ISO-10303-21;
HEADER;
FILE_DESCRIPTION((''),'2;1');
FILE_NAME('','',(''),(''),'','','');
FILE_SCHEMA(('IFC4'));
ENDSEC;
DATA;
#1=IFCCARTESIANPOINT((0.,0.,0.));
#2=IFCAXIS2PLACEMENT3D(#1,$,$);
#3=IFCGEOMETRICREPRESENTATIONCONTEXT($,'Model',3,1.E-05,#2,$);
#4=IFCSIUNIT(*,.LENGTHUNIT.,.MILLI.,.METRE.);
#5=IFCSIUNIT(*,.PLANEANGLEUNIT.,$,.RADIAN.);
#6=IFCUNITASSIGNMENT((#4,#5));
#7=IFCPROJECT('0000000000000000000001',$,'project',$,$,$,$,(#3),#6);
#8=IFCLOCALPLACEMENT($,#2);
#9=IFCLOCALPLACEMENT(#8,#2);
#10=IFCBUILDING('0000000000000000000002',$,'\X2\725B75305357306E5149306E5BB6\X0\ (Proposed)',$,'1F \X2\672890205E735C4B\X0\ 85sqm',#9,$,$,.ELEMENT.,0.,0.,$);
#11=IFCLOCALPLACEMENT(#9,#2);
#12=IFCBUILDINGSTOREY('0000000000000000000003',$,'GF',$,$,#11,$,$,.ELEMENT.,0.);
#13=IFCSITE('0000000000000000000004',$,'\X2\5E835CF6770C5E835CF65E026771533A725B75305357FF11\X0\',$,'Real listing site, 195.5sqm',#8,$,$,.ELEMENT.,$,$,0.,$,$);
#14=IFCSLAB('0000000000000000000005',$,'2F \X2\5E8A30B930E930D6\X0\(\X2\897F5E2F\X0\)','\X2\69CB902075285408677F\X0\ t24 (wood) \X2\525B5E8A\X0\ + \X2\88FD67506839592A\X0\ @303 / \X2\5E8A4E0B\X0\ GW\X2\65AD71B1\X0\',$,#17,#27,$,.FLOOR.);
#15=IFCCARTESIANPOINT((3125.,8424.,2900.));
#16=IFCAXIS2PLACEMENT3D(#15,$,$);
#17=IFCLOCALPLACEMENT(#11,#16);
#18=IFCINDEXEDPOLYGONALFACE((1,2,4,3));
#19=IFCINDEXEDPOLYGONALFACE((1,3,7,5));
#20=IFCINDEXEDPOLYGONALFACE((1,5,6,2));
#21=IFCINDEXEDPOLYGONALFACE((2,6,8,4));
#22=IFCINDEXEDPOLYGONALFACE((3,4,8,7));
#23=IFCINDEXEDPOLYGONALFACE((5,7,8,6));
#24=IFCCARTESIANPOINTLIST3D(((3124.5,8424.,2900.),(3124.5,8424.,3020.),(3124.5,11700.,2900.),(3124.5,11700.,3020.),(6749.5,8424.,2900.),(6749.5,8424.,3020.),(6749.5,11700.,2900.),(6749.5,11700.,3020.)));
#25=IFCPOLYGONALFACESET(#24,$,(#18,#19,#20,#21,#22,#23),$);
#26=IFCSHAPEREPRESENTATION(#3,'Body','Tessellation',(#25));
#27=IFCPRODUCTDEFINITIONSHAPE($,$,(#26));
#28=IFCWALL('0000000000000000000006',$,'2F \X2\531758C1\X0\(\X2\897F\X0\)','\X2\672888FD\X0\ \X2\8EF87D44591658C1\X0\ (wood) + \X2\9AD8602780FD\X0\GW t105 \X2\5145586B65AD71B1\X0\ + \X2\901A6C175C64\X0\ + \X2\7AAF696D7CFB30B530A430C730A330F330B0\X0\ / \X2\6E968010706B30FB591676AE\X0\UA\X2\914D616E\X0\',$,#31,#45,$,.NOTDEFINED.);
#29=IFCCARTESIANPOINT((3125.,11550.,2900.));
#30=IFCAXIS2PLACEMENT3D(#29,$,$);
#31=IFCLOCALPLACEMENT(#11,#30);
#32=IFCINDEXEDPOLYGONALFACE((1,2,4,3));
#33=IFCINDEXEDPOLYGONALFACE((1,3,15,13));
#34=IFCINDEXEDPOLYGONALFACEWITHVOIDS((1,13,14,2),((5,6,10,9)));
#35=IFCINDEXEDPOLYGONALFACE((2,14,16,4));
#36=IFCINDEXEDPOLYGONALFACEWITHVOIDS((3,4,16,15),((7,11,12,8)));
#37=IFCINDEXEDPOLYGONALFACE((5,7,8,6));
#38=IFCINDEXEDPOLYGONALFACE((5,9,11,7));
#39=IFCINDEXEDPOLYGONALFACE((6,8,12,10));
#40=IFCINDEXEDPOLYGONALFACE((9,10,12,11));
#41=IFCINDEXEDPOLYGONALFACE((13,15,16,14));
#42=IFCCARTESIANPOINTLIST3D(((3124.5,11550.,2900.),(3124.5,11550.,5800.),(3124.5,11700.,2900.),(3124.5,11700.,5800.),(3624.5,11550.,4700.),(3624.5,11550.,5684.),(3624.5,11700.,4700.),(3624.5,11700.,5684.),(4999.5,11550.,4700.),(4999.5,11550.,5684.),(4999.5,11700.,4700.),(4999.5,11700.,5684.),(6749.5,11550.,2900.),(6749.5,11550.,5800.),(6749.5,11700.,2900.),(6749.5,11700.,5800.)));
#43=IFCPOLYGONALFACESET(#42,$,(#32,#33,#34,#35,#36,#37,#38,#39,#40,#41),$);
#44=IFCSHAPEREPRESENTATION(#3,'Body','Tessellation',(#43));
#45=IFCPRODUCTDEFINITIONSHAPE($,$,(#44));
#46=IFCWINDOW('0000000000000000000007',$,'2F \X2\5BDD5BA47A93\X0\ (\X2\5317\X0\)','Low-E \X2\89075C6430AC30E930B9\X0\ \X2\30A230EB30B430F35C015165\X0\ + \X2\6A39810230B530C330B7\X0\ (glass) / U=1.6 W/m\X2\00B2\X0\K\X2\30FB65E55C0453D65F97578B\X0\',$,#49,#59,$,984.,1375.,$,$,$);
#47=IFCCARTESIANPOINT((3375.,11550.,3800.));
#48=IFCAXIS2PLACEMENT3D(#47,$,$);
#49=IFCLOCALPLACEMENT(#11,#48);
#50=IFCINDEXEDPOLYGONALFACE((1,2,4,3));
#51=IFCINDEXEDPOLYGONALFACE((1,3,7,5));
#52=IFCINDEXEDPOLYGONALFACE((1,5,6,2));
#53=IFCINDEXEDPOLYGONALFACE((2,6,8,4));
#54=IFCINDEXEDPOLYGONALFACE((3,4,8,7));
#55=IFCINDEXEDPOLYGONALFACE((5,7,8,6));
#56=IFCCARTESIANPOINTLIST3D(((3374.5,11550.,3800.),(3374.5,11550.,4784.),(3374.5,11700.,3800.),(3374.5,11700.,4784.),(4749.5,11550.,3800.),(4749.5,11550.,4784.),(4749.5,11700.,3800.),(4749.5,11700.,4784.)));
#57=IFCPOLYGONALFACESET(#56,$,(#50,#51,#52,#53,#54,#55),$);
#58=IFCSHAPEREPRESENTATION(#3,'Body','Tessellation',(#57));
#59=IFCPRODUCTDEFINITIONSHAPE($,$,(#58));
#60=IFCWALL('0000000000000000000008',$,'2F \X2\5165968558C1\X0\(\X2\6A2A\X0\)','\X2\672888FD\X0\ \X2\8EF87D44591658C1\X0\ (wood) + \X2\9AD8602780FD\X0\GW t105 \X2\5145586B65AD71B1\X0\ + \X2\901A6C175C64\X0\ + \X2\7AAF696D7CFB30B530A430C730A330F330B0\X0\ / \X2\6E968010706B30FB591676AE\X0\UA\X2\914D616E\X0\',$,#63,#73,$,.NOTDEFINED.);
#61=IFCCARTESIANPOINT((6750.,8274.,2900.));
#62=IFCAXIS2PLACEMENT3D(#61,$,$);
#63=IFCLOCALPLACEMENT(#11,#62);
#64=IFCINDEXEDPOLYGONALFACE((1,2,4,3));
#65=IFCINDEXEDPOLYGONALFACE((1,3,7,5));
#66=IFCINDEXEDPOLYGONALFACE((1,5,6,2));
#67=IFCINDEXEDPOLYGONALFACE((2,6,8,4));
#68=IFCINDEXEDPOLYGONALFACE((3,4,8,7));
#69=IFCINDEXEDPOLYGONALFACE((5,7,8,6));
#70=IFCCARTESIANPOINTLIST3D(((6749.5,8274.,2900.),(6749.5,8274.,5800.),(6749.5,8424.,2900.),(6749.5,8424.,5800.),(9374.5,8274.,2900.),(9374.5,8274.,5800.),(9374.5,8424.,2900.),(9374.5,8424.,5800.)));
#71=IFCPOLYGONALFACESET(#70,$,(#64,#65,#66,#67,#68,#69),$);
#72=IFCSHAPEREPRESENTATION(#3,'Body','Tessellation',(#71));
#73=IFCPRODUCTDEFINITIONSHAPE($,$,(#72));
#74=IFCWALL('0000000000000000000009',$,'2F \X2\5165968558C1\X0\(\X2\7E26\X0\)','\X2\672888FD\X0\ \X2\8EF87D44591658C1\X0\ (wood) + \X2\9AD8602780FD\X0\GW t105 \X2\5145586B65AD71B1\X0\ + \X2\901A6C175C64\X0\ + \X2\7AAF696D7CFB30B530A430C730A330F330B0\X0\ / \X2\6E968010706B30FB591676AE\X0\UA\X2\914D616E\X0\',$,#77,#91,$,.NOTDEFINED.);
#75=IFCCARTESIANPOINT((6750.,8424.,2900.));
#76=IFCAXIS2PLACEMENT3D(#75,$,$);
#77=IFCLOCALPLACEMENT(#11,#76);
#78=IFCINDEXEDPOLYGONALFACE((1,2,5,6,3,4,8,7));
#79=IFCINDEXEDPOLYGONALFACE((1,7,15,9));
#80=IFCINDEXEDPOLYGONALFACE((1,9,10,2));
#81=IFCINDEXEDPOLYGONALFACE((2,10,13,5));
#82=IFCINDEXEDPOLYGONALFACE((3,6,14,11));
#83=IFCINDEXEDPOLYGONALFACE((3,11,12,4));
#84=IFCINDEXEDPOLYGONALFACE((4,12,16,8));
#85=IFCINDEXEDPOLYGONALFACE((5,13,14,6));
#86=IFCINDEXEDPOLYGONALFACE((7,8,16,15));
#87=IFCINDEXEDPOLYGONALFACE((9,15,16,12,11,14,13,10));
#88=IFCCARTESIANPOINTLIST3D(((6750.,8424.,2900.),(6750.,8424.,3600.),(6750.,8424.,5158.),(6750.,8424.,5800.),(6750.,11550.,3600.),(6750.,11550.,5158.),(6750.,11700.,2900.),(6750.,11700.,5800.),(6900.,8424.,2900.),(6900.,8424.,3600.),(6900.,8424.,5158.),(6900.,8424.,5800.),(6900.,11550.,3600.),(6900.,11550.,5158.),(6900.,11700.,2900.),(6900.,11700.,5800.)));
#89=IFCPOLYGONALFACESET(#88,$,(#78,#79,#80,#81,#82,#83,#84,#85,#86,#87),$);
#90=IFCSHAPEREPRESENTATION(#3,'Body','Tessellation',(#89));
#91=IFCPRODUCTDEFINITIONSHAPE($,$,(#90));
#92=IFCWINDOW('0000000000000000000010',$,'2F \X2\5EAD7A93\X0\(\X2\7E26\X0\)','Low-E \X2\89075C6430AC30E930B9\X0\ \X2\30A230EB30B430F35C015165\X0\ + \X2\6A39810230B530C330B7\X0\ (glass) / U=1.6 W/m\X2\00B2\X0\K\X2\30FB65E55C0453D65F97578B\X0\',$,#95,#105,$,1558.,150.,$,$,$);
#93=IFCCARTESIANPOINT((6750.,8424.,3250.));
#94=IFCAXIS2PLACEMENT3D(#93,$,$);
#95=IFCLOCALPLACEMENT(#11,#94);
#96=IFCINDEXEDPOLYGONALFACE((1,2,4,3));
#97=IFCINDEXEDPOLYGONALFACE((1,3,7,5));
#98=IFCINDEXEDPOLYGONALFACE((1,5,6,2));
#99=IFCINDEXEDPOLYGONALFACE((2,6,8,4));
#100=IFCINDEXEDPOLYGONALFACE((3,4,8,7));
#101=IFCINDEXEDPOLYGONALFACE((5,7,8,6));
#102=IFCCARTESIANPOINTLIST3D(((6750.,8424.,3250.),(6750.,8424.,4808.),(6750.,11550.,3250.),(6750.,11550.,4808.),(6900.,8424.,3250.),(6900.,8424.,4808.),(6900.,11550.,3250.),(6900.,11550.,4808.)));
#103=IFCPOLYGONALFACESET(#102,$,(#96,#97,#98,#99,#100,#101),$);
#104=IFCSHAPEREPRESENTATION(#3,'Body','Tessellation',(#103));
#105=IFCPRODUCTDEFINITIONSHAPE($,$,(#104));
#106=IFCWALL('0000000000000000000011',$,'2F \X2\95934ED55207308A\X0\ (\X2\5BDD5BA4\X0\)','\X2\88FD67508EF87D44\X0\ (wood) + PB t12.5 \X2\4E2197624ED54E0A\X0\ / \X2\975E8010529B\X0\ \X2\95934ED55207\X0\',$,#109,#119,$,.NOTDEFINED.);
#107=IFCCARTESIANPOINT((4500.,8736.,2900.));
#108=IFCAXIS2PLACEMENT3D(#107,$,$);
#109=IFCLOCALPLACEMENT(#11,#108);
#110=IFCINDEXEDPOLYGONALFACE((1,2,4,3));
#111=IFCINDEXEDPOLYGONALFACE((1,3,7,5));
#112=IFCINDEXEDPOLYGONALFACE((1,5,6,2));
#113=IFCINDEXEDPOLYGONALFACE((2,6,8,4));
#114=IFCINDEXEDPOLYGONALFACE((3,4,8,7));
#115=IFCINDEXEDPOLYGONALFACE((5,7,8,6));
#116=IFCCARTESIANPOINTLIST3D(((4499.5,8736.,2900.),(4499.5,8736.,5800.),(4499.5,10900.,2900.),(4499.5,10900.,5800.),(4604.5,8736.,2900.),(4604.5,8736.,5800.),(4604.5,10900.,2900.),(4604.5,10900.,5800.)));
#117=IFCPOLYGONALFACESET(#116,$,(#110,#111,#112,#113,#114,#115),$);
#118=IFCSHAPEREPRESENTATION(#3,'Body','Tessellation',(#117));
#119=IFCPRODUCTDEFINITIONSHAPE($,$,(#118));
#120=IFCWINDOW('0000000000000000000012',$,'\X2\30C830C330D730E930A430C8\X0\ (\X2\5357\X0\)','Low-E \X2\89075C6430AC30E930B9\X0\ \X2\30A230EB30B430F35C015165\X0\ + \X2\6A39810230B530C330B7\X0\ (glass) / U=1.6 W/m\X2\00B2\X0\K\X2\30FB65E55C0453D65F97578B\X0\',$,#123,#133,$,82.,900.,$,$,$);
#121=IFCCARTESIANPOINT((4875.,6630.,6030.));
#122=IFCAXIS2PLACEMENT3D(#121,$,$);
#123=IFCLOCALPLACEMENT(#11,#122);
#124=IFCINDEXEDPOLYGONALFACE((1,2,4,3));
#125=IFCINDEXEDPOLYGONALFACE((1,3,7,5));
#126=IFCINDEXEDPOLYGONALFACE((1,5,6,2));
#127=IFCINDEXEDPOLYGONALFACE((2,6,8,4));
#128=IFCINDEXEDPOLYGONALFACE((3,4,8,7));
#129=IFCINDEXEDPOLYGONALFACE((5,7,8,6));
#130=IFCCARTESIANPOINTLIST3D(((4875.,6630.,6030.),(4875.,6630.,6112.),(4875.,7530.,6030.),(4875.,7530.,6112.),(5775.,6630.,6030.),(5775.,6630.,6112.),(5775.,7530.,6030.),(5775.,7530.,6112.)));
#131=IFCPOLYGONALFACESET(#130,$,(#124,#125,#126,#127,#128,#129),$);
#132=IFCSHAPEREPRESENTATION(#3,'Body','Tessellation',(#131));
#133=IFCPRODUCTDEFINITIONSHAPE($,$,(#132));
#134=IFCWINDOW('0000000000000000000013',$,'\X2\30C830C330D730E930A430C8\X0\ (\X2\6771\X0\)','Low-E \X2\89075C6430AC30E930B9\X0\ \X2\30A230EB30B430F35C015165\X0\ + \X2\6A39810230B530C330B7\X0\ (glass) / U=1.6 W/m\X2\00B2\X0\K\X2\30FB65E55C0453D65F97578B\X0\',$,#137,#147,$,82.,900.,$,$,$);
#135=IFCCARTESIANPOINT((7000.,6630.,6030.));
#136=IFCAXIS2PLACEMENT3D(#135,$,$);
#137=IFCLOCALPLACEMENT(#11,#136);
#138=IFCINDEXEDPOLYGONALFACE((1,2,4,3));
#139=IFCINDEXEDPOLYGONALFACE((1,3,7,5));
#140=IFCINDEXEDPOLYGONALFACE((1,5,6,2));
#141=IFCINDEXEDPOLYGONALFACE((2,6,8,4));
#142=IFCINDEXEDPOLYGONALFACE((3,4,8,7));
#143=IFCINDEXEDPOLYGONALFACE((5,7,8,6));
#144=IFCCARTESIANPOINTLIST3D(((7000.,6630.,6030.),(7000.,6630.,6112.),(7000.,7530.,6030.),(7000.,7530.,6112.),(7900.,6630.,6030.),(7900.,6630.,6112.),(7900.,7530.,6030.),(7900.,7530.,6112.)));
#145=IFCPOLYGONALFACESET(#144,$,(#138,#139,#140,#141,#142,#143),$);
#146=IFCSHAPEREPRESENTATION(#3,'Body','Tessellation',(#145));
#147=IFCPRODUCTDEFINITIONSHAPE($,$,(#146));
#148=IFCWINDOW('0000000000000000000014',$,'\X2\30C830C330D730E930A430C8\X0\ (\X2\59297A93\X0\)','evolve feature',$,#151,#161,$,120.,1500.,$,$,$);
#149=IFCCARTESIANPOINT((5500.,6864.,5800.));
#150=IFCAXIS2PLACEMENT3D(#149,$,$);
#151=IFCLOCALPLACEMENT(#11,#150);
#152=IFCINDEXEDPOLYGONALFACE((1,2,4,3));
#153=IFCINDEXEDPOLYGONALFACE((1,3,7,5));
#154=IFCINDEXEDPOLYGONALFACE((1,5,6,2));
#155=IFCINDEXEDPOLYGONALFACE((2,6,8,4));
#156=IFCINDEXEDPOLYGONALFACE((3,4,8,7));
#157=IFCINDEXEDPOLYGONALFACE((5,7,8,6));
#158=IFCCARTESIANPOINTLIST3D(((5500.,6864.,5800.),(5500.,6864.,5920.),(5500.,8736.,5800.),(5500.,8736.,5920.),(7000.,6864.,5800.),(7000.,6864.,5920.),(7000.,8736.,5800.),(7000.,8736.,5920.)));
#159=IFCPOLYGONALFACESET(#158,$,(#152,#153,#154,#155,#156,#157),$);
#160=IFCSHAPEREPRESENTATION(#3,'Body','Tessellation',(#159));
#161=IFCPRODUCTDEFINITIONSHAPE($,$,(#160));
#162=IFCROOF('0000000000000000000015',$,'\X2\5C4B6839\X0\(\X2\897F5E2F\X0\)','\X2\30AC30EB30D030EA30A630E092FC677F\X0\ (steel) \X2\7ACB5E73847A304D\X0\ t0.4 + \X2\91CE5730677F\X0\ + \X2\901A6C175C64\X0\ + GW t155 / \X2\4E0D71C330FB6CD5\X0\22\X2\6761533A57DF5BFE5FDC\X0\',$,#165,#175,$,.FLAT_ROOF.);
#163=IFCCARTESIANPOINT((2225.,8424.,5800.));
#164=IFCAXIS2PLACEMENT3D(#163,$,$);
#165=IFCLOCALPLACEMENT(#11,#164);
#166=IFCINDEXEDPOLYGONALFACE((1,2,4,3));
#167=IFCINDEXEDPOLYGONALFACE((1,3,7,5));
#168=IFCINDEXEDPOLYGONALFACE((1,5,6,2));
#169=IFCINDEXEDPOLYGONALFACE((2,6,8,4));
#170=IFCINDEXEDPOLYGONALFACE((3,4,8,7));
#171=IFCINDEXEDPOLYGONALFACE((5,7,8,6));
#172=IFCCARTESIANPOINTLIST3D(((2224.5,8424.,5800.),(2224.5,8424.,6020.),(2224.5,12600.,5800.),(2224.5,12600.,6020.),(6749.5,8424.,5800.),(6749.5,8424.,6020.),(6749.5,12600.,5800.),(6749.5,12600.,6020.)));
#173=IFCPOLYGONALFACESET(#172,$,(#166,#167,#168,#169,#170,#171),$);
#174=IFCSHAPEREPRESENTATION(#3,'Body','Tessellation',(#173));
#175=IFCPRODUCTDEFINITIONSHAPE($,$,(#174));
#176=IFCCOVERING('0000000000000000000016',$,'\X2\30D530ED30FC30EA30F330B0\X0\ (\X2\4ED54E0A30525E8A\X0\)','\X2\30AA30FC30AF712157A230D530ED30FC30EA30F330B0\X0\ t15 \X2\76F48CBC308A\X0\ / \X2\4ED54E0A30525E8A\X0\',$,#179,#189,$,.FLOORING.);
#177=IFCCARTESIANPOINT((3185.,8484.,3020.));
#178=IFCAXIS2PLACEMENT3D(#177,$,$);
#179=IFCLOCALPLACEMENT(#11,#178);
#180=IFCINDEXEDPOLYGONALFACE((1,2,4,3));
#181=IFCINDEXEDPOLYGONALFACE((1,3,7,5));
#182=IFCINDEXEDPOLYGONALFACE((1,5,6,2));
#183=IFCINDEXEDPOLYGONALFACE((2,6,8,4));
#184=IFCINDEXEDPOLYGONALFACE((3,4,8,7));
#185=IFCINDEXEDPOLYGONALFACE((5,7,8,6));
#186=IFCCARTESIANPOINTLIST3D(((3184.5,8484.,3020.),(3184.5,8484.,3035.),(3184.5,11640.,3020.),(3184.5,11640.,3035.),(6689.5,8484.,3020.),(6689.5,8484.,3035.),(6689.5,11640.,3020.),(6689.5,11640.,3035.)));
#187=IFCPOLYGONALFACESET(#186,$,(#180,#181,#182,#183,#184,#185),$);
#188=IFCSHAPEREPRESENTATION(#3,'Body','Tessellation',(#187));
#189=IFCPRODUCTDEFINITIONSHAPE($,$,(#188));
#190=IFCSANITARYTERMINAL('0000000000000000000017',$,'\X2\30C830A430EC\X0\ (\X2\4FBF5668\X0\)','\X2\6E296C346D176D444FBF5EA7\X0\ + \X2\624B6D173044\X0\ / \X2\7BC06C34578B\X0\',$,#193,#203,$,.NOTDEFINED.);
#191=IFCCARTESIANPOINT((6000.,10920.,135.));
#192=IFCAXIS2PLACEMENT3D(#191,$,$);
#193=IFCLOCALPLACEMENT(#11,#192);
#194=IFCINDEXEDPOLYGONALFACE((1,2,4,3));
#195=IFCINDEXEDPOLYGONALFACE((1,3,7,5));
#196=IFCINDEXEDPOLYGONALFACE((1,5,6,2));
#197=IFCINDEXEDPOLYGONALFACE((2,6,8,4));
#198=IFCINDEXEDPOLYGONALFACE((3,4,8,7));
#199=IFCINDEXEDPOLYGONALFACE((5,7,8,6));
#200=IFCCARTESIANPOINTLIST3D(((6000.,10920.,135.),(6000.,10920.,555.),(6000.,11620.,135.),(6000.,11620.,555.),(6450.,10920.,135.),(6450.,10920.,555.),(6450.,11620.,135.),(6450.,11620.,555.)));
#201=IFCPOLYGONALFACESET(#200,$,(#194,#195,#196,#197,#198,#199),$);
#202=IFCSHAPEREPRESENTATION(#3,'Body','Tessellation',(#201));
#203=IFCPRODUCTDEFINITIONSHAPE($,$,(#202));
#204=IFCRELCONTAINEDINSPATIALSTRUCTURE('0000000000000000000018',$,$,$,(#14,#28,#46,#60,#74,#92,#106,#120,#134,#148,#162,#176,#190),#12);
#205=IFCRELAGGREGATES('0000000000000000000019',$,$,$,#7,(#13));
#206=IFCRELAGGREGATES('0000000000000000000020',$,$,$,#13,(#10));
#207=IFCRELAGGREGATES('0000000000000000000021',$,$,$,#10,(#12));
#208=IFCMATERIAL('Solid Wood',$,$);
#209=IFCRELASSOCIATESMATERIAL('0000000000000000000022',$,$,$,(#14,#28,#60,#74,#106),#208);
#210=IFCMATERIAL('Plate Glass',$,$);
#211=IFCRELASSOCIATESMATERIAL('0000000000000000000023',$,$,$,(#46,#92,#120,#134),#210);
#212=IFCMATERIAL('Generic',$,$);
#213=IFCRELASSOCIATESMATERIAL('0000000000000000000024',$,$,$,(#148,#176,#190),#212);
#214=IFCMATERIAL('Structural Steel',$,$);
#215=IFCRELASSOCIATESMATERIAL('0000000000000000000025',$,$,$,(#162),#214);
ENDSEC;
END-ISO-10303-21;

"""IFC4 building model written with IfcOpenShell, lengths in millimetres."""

from ifc_helpers import new_model, si_unit, frame, frame_2d, origin, place, context, project, spatial, rectangle, extrude, material, element, fill, save


model = new_model("IFC4")

# Units and contexts
model_context = context("Model", 3, precision=1e-05, world=origin())
ifc_project = project(units=[si_unit("LENGTHUNIT", "METRE", prefix="MILLI"), si_unit("PLANEANGLEUNIT", "RADIAN")], contexts=[model_context])

# Site, building, storey
site_placement = place(None, origin())
site = spatial("IfcSite", under=ifc_project, at=site_placement, Name="広島県広島市東区牛田南１", ObjectType="Real listing site, 195.5sqm", CompositionType="ELEMENT", RefElevation=0.0)
building_placement = place(site_placement, origin())
building = spatial("IfcBuilding", under=site, at=building_placement, Name="牛田南の光の家 (Proposed)", ObjectType="1F 木造平屋 85sqm", CompositionType="ELEMENT", ElevationOfRefHeight=0.0, ElevationOfTerrain=0.0)
storey_placement = place(building_placement, origin())
storey = spatial("IfcBuildingStorey", under=building, at=storey_placement, Name="GF", CompositionType="ELEMENT", Elevation=0.0)

# Slab
ifc_material_1 = material(Name="Solid Wood")
slab_placement = place(storey_placement, frame((3125.0, 8424.0, 2900.0)))
element("IfcSlab", 1, at=slab_placement, inside=storey, material=ifc_material_1, Name="2F 床スラブ(西帯)", Description="構造用合板 t24 (wood) 剛床 + 製材根太 @303 / 床下 GW断熱", PredefinedType="FLOOR", context=model_context, shape_type="SweptSolid", body=[
    extrude(rectangle(XDim=3625.0, YDim=3276.0, at=frame_2d((1812.0, 1638.0))), frame((3125.0, 8424.0, 2900.0)), (0.0, 0.0, 1.0), 120.0),
])

# Wall, opening, window
wall_1_placement = place(storey_placement, frame((3125.0, 11550.0, 2900.0)))
wall_1 = element("IfcWall", 2, at=wall_1_placement, inside=storey, material=ifc_material_1, Name="2F 北壁(西)", Description="木製 軸組外壁 (wood) + 高性能GW t105 充填断熱 + 通気層 + 窯業系サイディング / 準耐火・外皮UA配慮", PredefinedType="NOTDEFINED", context=model_context, shape_type="SweptSolid", body=[
    extrude(rectangle(XDim=3625.0, YDim=150.0, at=frame_2d((1812.0, 75.0))), frame((3125.0, 11550.0, 2900.0)), (0.0, 0.0, 1.0), 2900.0),
])
opening_1_placement = place(storey_placement, frame((3375.0, 11550.0, 3800.0)))
opening_1 = element("IfcOpeningElement", 3, at=opening_1_placement, cuts=wall_1, PredefinedType="NOTDEFINED", context=model_context, shape_type="SweptSolid", body=[
    extrude(rectangle(XDim=1375.0, YDim=150.0, at=frame_2d((687.0, 75.0))), frame((3375.0, 11550.0, 3800.0)), (0.0, 0.0, 1.0), 984.0),
])
ifc_material_2 = material(Name="Plate Glass")
window_1_placement = place(storey_placement, frame((3375.0, 11550.0, 3800.0)))
window_1 = element("IfcWindow", 4, at=window_1_placement, inside=storey, material=ifc_material_2, Name="2F 寝室窓 (北)", Description="Low-E 複層ガラス アルゴン封入 + 樹脂サッシ (glass) / U=1.6 W/m²K・日射取得型", OverallHeight=984.0, OverallWidth=1375.0, context=model_context, shape_type="SweptSolid", body=[
    extrude(rectangle(XDim=1375.0, YDim=150.0, at=frame_2d((687.0, 75.0))), frame((3375.0, 11550.0, 3800.0)), (0.0, 0.0, 1.0), 984.0),
])
fill(opening_1, window_1)

# Wall
wall_2_placement = place(storey_placement, frame((6750.0, 8274.0, 2900.0)))
element("IfcWall", 5, at=wall_2_placement, inside=storey, material=ifc_material_1, Name="2F 入隅壁(横)", Description="木製 軸組外壁 (wood) + 高性能GW t105 充填断熱 + 通気層 + 窯業系サイディング / 準耐火・外皮UA配慮", PredefinedType="NOTDEFINED", context=model_context, shape_type="SweptSolid", body=[
    extrude(rectangle(XDim=2625.0, YDim=150.0, at=frame_2d((1312.0, 75.0))), frame((6750.0, 8274.0, 2900.0)), (0.0, 0.0, 1.0), 2900.0),
])

# Wall, opening, window
wall_3_placement = place(storey_placement, frame((6750.0, 8424.0, 2900.0)))
wall_3 = element("IfcWall", 6, at=wall_3_placement, inside=storey, material=ifc_material_1, Name="2F 入隅壁(縦)", Description="木製 軸組外壁 (wood) + 高性能GW t105 充填断熱 + 通気層 + 窯業系サイディング / 準耐火・外皮UA配慮", PredefinedType="NOTDEFINED", context=model_context, shape_type="SweptSolid", body=[
    extrude(rectangle(XDim=150.0, YDim=3276.0, at=frame_2d((75.0, 1638.0))), frame((6750.0, 8424.0, 2900.0)), (0.0, 0.0, 1.0), 2900.0),
])
opening_2_placement = place(storey_placement, frame((6750.0, 8424.0, 3250.0)))
opening_2 = element("IfcOpeningElement", 7, at=opening_2_placement, cuts=wall_3, PredefinedType="NOTDEFINED", context=model_context, shape_type="SweptSolid", body=[
    extrude(rectangle(XDim=150.0, YDim=3126.0, at=frame_2d((75.0, 1563.0))), frame((6750.0, 8424.0, 3250.0)), (0.0, 0.0, 1.0), 1558.0),
])
window_2_placement = place(storey_placement, frame((6750.0, 8424.0, 3250.0)))
window_2 = element("IfcWindow", 8, at=window_2_placement, inside=storey, material=ifc_material_2, Name="2F 庭窓(縦)", Description="Low-E 複層ガラス アルゴン封入 + 樹脂サッシ (glass) / U=1.6 W/m²K・日射取得型", OverallHeight=1558.0, OverallWidth=150.0, context=model_context, shape_type="SweptSolid", body=[
    extrude(rectangle(XDim=150.0, YDim=3126.0, at=frame_2d((75.0, 1563.0))), frame((6750.0, 8424.0, 3250.0)), (0.0, 0.0, 1.0), 1558.0),
])
fill(opening_2, window_2)

# Wall
wall_4_placement = place(storey_placement, frame((4500.0, 8736.0, 2900.0)))
element("IfcWall", 9, at=wall_4_placement, inside=storey, material=ifc_material_1, Name="2F 間仕切り (寝室)", Description="製材軸組 (wood) + PB t12.5 両面仕上 / 非耐力 間仕切", PredefinedType="NOTDEFINED", context=model_context, shape_type="SweptSolid", body=[
    extrude(rectangle(XDim=105.0, YDim=2164.0, at=frame_2d((52.0, 1082.0))), frame((4500.0, 8736.0, 2900.0)), (0.0, 0.0, 1.0), 2900.0),
])

# Windows
window_3_placement = place(storey_placement, frame((4875.0, 6630.0, 6030.0)))
element("IfcWindow", 10, at=window_3_placement, inside=storey, material=ifc_material_2, Name="トップライト (南)", Description="Low-E 複層ガラス アルゴン封入 + 樹脂サッシ (glass) / U=1.6 W/m²K・日射取得型", OverallHeight=82.0, OverallWidth=900.0, context=model_context, shape_type="SweptSolid", body=[
    extrude(rectangle(XDim=900.0, YDim=900.0, at=frame_2d((450.0, 450.0))), frame((4875.0, 6630.0, 6030.0)), (0.0, 0.0, 1.0), 82.0),
])
window_4_placement = place(storey_placement, frame((7000.0, 6630.0, 6030.0)))
element("IfcWindow", 11, at=window_4_placement, inside=storey, material=ifc_material_2, Name="トップライト (東)", Description="Low-E 複層ガラス アルゴン封入 + 樹脂サッシ (glass) / U=1.6 W/m²K・日射取得型", OverallHeight=82.0, OverallWidth=900.0, context=model_context, shape_type="SweptSolid", body=[
    extrude(rectangle(XDim=900.0, YDim=900.0, at=frame_2d((450.0, 450.0))), frame((7000.0, 6630.0, 6030.0)), (0.0, 0.0, 1.0), 82.0),
])
ifc_material_3 = material(Name="Generic")
window_5_placement = place(storey_placement, frame((5500.0, 6864.0, 5800.0)))
element("IfcWindow", 12, at=window_5_placement, inside=storey, material=ifc_material_3, Name="トップライト (天窓)", Description="evolve feature", OverallHeight=120.0, OverallWidth=1500.0, context=model_context, shape_type="SweptSolid", body=[
    extrude(rectangle(XDim=1500.0, YDim=1872.0, at=frame_2d((750.0, 936.0))), frame((5500.0, 6864.0, 5800.0)), (0.0, 0.0, 1.0), 120.0),
])

# Roof
ifc_material_4 = material(Name="Structural Steel")
for number, where, name in (
    (13, (2225.0, 8424.0, 5800.0), "屋根(西帯)"),
):
    element("IfcRoof", number, at=place(storey_placement, frame(where)), inside=storey, material=ifc_material_4, Name=name, Description="ガルバリウム鋼板 (steel) 立平葺き t0.4 + 野地板 + 通気層 + GW t155 / 不燃・法22条区域対応", PredefinedType="FLAT_ROOF", context=model_context, shape_type="SweptSolid", body=[
        extrude(rectangle(XDim=4525.0, YDim=4176.0, at=frame_2d((2262.0, 2088.0))), frame((2225.0, 8424.0, 5800.0)), (0.0, 0.0, 1.0), 220.0),
    ])

# Covering
covering_placement = place(storey_placement, frame((3185.0, 8484.0, 3020.0)))
element("IfcCovering", 14, at=covering_placement, inside=storey, material=ifc_material_3, Name="フローリング (仕上げ床)", Description="オーク無垢フローリング t15 直貼り / 仕上げ床", PredefinedType="FLOORING", context=model_context, shape_type="SweptSolid", body=[
    extrude(rectangle(XDim=3505.0, YDim=3156.0, at=frame_2d((1752.0, 1578.0))), frame((3185.0, 8484.0, 3020.0)), (0.0, 0.0, 1.0), 15.0),
])

# Sanitary terminal
sanitary_terminal_placement = place(storey_placement, frame((6000.0, 10920.0, 135.0)))
element("IfcSanitaryTerminal", 15, at=sanitary_terminal_placement, inside=storey, material=ifc_material_3, Name="トイレ (便器)", Description="温水洗浄便座 + 手洗い / 節水型", PredefinedType="NOTDEFINED", context=model_context, shape_type="SweptSolid", body=[
    extrude(rectangle(XDim=450.0, YDim=700.0, at=frame_2d((225.0, 350.0))), frame((6000.0, 10920.0, 135.0)), (0.0, 0.0, 1.0), 420.0),
])

save(model, "model.ifc")
